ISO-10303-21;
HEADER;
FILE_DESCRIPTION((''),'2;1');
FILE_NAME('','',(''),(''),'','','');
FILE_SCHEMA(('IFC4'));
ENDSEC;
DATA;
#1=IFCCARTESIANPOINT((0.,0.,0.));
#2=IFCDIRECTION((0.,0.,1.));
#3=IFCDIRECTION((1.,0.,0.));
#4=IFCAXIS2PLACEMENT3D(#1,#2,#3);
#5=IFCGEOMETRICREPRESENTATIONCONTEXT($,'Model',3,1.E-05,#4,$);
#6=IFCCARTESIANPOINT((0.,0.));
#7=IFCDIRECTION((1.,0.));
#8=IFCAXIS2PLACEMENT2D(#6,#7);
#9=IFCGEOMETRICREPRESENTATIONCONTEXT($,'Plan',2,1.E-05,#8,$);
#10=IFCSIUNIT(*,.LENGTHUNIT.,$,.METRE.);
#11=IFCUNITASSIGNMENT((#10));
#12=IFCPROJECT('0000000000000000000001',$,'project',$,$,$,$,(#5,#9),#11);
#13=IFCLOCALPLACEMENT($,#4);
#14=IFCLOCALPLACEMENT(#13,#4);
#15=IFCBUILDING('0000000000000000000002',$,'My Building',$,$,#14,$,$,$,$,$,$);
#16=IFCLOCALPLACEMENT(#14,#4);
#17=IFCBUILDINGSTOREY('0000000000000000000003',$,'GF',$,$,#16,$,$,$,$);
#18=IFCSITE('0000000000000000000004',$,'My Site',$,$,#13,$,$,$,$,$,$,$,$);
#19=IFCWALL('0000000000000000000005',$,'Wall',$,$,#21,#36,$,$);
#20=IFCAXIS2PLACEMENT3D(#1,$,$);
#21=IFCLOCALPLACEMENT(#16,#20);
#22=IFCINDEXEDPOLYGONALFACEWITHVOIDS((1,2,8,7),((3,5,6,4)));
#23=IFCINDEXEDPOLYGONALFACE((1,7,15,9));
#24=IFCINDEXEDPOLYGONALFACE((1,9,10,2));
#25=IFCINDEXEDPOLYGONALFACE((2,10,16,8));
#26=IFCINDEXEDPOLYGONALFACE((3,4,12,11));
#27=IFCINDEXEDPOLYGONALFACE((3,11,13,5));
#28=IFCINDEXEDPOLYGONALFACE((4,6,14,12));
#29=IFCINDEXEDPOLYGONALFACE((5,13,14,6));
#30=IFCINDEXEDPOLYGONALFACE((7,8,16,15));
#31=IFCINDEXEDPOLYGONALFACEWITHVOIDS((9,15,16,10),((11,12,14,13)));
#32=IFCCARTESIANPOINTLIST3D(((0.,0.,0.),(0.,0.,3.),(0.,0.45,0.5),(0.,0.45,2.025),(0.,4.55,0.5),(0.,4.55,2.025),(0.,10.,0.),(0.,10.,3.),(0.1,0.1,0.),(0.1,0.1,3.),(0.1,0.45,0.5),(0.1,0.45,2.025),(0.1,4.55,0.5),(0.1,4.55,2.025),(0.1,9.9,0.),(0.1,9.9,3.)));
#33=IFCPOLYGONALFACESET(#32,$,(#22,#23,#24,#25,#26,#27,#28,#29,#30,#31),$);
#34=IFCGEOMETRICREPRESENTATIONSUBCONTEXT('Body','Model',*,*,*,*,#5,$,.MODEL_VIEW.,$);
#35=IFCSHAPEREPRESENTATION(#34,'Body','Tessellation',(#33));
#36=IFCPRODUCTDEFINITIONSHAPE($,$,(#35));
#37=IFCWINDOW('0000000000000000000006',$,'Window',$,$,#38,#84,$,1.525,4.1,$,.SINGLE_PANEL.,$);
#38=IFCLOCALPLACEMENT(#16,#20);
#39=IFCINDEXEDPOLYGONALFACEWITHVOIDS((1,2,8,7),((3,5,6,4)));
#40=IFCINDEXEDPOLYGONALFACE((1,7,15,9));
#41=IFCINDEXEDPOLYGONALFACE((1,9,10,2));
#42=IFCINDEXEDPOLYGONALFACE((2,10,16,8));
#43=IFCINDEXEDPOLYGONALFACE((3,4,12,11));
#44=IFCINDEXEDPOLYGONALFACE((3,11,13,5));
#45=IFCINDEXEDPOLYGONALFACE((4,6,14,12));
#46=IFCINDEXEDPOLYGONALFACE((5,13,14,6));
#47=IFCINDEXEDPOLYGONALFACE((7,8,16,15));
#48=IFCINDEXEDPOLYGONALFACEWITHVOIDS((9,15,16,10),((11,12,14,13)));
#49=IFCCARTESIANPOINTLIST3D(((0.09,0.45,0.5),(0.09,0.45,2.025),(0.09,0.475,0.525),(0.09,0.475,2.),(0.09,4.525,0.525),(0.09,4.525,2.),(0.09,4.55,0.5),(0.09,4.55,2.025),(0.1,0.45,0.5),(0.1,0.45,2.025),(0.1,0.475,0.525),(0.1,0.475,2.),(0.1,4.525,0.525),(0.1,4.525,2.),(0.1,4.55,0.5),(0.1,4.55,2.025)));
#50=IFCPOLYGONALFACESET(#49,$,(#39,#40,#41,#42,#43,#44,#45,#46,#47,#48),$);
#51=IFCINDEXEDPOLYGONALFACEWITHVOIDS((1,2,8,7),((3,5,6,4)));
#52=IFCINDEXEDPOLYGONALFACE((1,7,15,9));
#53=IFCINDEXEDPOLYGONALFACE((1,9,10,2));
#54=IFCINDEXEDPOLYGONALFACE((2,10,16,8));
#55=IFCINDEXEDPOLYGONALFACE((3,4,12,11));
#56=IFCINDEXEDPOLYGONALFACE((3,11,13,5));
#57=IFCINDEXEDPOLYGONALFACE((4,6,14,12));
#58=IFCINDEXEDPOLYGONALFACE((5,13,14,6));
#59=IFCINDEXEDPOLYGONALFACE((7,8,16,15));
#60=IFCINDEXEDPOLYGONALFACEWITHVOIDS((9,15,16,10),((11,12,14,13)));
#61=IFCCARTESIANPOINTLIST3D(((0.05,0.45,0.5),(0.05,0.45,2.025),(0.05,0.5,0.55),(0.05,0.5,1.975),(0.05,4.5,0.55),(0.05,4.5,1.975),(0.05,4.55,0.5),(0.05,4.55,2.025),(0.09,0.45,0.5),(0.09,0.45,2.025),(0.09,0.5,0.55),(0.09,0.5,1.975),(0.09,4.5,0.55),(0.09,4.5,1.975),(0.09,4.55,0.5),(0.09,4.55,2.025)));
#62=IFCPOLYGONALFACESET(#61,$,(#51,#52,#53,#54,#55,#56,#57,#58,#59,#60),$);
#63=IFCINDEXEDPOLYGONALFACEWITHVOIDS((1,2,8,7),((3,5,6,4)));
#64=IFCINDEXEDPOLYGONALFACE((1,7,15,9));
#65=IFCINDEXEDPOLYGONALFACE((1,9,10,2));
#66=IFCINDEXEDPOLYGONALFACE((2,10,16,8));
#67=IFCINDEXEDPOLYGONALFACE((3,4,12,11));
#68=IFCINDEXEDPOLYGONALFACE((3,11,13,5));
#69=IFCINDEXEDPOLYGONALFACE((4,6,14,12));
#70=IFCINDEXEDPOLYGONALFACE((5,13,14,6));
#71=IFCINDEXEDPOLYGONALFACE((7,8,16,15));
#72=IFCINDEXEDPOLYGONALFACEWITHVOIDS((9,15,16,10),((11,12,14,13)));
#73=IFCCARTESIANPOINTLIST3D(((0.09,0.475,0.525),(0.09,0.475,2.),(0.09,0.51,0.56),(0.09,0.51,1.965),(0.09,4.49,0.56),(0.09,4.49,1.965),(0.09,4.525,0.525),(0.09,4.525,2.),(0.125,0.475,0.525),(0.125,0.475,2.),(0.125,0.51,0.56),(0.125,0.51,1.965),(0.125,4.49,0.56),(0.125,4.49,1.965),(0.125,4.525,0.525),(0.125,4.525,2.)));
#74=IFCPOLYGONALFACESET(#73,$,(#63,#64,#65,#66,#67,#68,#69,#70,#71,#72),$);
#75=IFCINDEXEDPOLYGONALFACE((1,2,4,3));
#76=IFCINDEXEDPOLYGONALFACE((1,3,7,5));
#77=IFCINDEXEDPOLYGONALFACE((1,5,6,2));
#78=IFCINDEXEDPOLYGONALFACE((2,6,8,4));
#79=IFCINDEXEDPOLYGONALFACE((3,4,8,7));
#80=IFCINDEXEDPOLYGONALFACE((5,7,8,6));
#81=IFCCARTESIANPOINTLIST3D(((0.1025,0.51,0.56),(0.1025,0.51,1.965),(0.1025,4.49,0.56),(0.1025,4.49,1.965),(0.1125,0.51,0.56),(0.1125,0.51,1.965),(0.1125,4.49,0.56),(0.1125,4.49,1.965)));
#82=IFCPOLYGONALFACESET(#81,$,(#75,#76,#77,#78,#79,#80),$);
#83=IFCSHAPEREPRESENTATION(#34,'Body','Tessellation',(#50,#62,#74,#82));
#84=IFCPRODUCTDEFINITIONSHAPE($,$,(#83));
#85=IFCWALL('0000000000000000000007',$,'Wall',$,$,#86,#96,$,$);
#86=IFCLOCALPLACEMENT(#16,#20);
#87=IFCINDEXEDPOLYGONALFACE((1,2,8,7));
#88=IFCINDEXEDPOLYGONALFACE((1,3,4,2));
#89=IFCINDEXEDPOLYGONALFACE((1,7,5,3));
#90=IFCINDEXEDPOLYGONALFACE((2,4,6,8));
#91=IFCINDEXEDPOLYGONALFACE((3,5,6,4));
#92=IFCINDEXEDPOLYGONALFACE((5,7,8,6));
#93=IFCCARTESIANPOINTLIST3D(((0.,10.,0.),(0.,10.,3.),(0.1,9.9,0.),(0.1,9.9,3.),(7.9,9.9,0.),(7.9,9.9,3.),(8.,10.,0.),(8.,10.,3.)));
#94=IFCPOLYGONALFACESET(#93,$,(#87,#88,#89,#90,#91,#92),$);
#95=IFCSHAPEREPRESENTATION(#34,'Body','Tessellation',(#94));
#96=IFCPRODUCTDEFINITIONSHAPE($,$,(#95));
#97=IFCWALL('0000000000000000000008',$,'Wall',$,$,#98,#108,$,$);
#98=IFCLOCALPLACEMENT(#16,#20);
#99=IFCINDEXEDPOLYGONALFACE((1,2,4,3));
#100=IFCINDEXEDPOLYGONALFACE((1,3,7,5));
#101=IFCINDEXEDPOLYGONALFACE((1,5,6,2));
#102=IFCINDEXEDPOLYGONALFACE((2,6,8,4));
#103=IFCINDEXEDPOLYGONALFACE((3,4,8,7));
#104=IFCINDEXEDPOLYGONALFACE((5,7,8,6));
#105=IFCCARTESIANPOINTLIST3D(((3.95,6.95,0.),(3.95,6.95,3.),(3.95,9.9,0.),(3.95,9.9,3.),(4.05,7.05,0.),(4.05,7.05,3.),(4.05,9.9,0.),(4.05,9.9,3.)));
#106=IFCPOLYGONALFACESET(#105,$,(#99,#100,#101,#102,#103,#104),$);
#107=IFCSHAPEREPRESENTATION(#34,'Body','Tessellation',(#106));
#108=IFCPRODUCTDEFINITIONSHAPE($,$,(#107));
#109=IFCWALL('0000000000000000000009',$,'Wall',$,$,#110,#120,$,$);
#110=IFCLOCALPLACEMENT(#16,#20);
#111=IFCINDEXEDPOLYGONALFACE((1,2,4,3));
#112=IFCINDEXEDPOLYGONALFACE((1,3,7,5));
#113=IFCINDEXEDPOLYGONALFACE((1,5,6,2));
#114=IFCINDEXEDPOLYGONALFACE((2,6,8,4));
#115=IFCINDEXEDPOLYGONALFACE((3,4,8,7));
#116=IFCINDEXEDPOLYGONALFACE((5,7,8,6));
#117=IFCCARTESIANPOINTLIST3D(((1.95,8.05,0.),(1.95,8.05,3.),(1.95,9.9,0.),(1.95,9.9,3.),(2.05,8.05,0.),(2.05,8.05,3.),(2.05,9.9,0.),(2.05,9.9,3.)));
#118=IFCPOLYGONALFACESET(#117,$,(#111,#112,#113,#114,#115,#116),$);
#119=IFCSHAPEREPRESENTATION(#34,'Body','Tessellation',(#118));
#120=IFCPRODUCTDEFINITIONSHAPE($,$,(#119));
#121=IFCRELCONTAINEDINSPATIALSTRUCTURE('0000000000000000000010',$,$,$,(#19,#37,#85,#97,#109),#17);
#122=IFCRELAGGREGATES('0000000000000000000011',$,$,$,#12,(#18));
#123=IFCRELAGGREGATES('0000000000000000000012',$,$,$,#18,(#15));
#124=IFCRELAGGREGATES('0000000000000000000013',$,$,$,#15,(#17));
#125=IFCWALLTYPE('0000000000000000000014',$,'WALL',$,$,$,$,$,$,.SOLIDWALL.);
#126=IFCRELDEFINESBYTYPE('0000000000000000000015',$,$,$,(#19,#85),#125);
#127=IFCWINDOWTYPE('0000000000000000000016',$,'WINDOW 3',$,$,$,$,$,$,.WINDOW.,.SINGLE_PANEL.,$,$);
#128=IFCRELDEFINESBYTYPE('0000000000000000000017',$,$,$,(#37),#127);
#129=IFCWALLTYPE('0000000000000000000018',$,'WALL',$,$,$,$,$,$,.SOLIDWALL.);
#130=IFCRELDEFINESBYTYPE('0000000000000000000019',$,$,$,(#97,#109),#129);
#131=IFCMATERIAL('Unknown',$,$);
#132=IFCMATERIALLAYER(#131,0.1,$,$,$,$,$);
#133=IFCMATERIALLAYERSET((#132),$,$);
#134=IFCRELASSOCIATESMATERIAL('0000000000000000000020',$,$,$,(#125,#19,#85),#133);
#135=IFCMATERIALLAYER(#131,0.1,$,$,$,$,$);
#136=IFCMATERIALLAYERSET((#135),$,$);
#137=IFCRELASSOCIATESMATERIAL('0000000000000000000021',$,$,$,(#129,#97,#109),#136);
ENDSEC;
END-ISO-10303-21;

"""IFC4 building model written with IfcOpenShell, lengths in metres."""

from ifc_helpers import new_model, entity, si_unit, frame, origin_with_axes, origin_2d_with_axis, place, context, subcontext, project, spatial, line, indexed_curve, outline, extrude, shape, source, transform, mapped, material, layer, layer_set, layer_usage, type_object, type_shapes, element, fill, save


model = new_model("IFC4")

# Units and contexts
model_context = context("Model", 3, precision=1e-05, world=origin_with_axes())
plan_context = context("Plan", 2, precision=1e-05, world=origin_2d_with_axis())
body_context_1 = subcontext(model_context, "Body", "Model", "MODEL_VIEW")
body_context_2 = subcontext(plan_context, "Body", "Plan", "PLAN_VIEW")
ifc_project = project(units=[si_unit("LENGTHUNIT", "METRE")], contexts=[model_context, plan_context])

# Site, building, storey
site_placement = place(None, origin_with_axes())
site = spatial("IfcSite", under=ifc_project, at=site_placement, Name="My Site")
building_placement = place(site_placement, origin_with_axes())
building = spatial("IfcBuilding", under=site, at=building_placement, Name="My Building")
storey_placement = place(building_placement, origin_with_axes())
storey = spatial("IfcBuildingStorey", under=building, at=storey_placement, Name="GF")

# Shared definitions
ifc_material = material(Name="Unknown")

# Wall, opening, window
ifc_layer_1 = layer(ifc_material, 0.1)
ifc_layer_set_1 = layer_set([ifc_layer_1])
ifc_layer_usage_1 = layer_usage(ifc_layer_set_1, "AXIS2", "POSITIVE", 0.0)
wall_type_1 = type_object("IfcWallType", Name="WALL", PredefinedType="SOLIDWALL", material=ifc_layer_set_1)
wall_1_placement = place(storey_placement, frame((0.0, 10.0, 0.0), z_axis=(0.0, 0.0, 1.0), x_axis=(0.0, -1.0, 0.0)))
wall_1 = element("IfcWall", 1, at=wall_1_placement, inside=storey, type_object=wall_type_1, material=ifc_layer_usage_1, Name="Wall", context=body_context_1, shape_type="SweptSolid", body=[
    extrude(outline(indexed_curve([(0.0, 0.0), (0.1, 0.1), (9.9, 0.1), (10.0, 0.0)], segments=[line(1, 2, 3, 4, 1)])), origin_with_axes(), (0.0, 0.0, 1.0), 3.0),
])
shared_shape_1 = source(origin_with_axes(), body_context_1, "Body", "SweptSolid", [
    extrude(outline(indexed_curve([(0.0, 0.0), (4.1, 0.0), (4.1, 1.525), (0.0, 1.525)], segments=[line(1, 2, 3, 4, 1)])), frame((0.0, -0.6, 0.0), z_axis=(0.0, -1.0, 0.0), x_axis=(1.0, 0.0, 0.0)), (0.0, 0.0, -1.0), 1.2),
])
opening_1_placement = place(wall_1_placement, frame((5.45, 0.0, 0.5), z_axis=(0.0, 0.0, 1.0), x_axis=(1.0, 0.0, 0.0)))
opening_1 = element("IfcOpeningElement", 2, at=opening_1_placement, cuts=wall_1, PredefinedType="OPENING", context=body_context_1, shape_type="MappedRepresentation", body=[
    mapped(shared_shape_1, transform((0.0, 0.0, 0.0), x_axis=(1.0, 0.0, 0.0), y_axis=(0.0, 1.0, 0.0), z_axis=(0.0, 0.0, 1.0), scale=1.0)),
])
window_type = type_object("IfcWindowType", Name="WINDOW 3", PartitioningType="SINGLE_PANEL", PredefinedType="WINDOW")
shared_shape_2 = source(origin_with_axes(), body_context_1, "Body", "SweptSolid", [
    extrude(outline(indexed_curve([(0.0, 0.0), (4.1, 0.0), (4.1, 1.525), (0.0, 1.525)], segments=[line(1, 2, 3, 4, 1)]), holes=[indexed_curve([(0.025, 0.025), (4.075, 0.025), (4.075, 1.5), (0.025, 1.5)], segments=[line(1, 2, 3, 4, 1)])]), frame((0.0, 0.09, 0.0), z_axis=(0.0, -1.0, 0.0), x_axis=(1.0, 0.0, 0.0)), (0.0, 0.0, -1.0), 0.01),
    extrude(outline(indexed_curve([(0.0, 0.0), (4.1, 0.0), (4.1, 1.525), (0.0, 1.525)], segments=[line(1, 2, 3, 4, 1)]), holes=[indexed_curve([(0.05, 0.05), (4.05, 0.05), (4.05, 1.475), (0.05, 1.475)], segments=[line(1, 2, 3, 4, 1)])]), frame((0.0, 0.05, 0.0), z_axis=(0.0, -1.0, 0.0), x_axis=(1.0, 0.0, 0.0)), (0.0, 0.0, -1.0), 0.04),
    extrude(outline(indexed_curve([(0.0, 0.0), (4.05, 0.0), (4.05, 1.475), (0.0, 1.475)], segments=[line(1, 2, 3, 4, 1)]), holes=[indexed_curve([(0.035, 0.035), (4.015, 0.035), (4.015, 1.44), (0.035, 1.44)], segments=[line(1, 2, 3, 4, 1)])]), frame((0.025, 0.09, 0.025), z_axis=(0.0, -1.0, 0.0), x_axis=(1.0, 0.0, 0.0)), (0.0, 0.0, -1.0), 0.035),
    extrude(outline(indexed_curve([(0.035, 0.035), (4.015, 0.035), (4.015, 1.44), (0.035, 1.44)], segments=[line(1, 2, 3, 4, 1)])), frame((0.025, 0.1025, 0.025), z_axis=(0.0, -1.0, 0.0), x_axis=(1.0, 0.0, 0.0)), (0.0, 0.0, -1.0), 0.01),
])
shared_shape_3 = source(origin_with_axes(), body_context_2, "Body", "Curve2D", [
    entity("IfcIndexedPolyCurve", entity("IfcCartesianPointList2D", [[0.05, 0.05], [4.05, 0.05]])),
    entity("IfcIndexedPolyCurve", entity("IfcCartesianPointList2D", [[0.0, 0.1], [0.025, 0.1], [0.025, 0.09], [0.05, 0.09], [0.05, 0.05], [0.0, 0.05]]), [entity("IfcLineIndex", [1, 2, 3, 4, 5, 6, 1])]),
    entity("IfcIndexedPolyCurve", entity("IfcCartesianPointList2D", [[4.1, 0.1], [4.075, 0.1], [4.075, 0.09], [4.05, 0.09], [4.05, 0.05], [4.1, 0.05]]), [entity("IfcLineIndex", [1, 2, 3, 4, 5, 6, 1])]),
    entity("IfcIndexedPolyCurve", entity("IfcCartesianPointList2D", [[0.025, 0.09], [0.06, 0.09], [0.06, 0.125], [0.025, 0.125]]), [entity("IfcLineIndex", [1, 2, 3, 4, 1])]),
    entity("IfcIndexedPolyCurve", entity("IfcCartesianPointList2D", [[4.075, 0.09], [4.04, 0.09], [4.04, 0.125], [4.075, 0.125]]), [entity("IfcLineIndex", [1, 2, 3, 4, 1])]),
    entity("IfcIndexedPolyCurve", entity("IfcCartesianPointList2D", [[0.06, 0.09], [4.04, 0.09]])),
    entity("IfcIndexedPolyCurve", entity("IfcCartesianPointList2D", [[0.06, 0.125], [4.04, 0.125]])),
    entity("IfcIndexedPolyCurve", entity("IfcCartesianPointList2D", [[0.06, 0.1075], [4.04, 0.1075]])),
])
type_shapes(window_type, [shared_shape_2, shared_shape_3])
window_placement = place(opening_1_placement, frame((0.0, 0.0, 0.0), z_axis=(0.0, 0.0, 1.0), x_axis=(1.0, 0.0, 0.0)))
window = element("IfcWindow", 3, at=window_placement, inside=storey, type_object=window_type, Name="Window", OverallHeight=1.525, OverallWidth=4.1, PartitioningType="SINGLE_PANEL", shapes=[
    shape(body_context_1, "Body", "MappedRepresentation", [mapped(shared_shape_2, transform((0.0, 0.0, 0.0), x_axis=(1.0, 0.0, 0.0), y_axis=(0.0, 1.0, 0.0), z_axis=(0.0, 0.0, 1.0), scale=1.0))]),
    shape(body_context_2, "Body", "MappedRepresentation", [mapped(shared_shape_3, transform((0.0, 0.0, 0.0), x_axis=(1.0, 0.0, 0.0), y_axis=(0.0, 1.0, 0.0), z_axis=(0.0, 0.0, 1.0), scale=1.0))]),
])
fill(opening_1, window)

# Walls
ifc_layer_usage_2 = layer_usage(ifc_layer_set_1, "AXIS2", "POSITIVE", 0.0)
wall_2_placement = place(storey_placement, frame((8.0, 10.0, 0.0), z_axis=(0.0, 0.0, 1.0), x_axis=(-1.0, 0.0, 0.0)))
element("IfcWall", 4, at=wall_2_placement, inside=storey, type_object=wall_type_1, material=ifc_layer_usage_2, Name="Wall", context=body_context_1, shape_type="SweptSolid", body=[
    extrude(outline(indexed_curve([(0.0, 0.0), (0.1, 0.1), (7.9, 0.1), (8.0, 0.0)], segments=[line(1, 2, 3, 4, 1)])), origin_with_axes(), (0.0, 0.0, 1.0), 3.0),
])
ifc_layer_2 = layer(ifc_material, 0.1)
ifc_layer_set_2 = layer_set([ifc_layer_2])
ifc_layer_usage_3 = layer_usage(ifc_layer_set_2, "AXIS2", "POSITIVE", 0.0)
wall_type_2 = type_object("IfcWallType", Name="WALL", PredefinedType="SOLIDWALL", material=ifc_layer_set_2)
wall_3_placement = place(storey_placement, frame((3.95, 9.9, 0.0), z_axis=(0.0, 0.0, 1.0), x_axis=(0.0, -1.0, 0.0)))
element("IfcWall", 5, at=wall_3_placement, inside=storey, type_object=wall_type_2, material=ifc_layer_usage_3, Name="Wall", context=body_context_1, shape_type="SweptSolid", body=[
    extrude(outline(indexed_curve([(0.0, 0.0), (0.0, 0.1), (2.85, 0.1), (2.95, 0.0)], segments=[line(1, 2, 3, 4, 1)])), origin_with_axes(), (0.0, 0.0, 1.0), 3.0),
])
ifc_layer_usage_4 = layer_usage(ifc_layer_set_2, "AXIS2", "POSITIVE", 0.0)
wall_4_placement = place(storey_placement, frame((1.95, 9.9, 0.0), z_axis=(0.0, 0.0, 1.0), x_axis=(0.0, -1.0, 0.0)))
element("IfcWall", 6, at=wall_4_placement, inside=storey, type_object=wall_type_2, material=ifc_layer_usage_4, Name="Wall", context=body_context_1, shape_type="SweptSolid", body=[
    extrude(outline(indexed_curve([(0.0, 0.0), (0.0, 0.1), (1.85, 0.1), (1.85, 0.0)], segments=[line(1, 2, 3, 4, 1)])), origin_with_axes(), (0.0, 0.0, 1.0), 3.0),
])

save(model, "model.ifc")
